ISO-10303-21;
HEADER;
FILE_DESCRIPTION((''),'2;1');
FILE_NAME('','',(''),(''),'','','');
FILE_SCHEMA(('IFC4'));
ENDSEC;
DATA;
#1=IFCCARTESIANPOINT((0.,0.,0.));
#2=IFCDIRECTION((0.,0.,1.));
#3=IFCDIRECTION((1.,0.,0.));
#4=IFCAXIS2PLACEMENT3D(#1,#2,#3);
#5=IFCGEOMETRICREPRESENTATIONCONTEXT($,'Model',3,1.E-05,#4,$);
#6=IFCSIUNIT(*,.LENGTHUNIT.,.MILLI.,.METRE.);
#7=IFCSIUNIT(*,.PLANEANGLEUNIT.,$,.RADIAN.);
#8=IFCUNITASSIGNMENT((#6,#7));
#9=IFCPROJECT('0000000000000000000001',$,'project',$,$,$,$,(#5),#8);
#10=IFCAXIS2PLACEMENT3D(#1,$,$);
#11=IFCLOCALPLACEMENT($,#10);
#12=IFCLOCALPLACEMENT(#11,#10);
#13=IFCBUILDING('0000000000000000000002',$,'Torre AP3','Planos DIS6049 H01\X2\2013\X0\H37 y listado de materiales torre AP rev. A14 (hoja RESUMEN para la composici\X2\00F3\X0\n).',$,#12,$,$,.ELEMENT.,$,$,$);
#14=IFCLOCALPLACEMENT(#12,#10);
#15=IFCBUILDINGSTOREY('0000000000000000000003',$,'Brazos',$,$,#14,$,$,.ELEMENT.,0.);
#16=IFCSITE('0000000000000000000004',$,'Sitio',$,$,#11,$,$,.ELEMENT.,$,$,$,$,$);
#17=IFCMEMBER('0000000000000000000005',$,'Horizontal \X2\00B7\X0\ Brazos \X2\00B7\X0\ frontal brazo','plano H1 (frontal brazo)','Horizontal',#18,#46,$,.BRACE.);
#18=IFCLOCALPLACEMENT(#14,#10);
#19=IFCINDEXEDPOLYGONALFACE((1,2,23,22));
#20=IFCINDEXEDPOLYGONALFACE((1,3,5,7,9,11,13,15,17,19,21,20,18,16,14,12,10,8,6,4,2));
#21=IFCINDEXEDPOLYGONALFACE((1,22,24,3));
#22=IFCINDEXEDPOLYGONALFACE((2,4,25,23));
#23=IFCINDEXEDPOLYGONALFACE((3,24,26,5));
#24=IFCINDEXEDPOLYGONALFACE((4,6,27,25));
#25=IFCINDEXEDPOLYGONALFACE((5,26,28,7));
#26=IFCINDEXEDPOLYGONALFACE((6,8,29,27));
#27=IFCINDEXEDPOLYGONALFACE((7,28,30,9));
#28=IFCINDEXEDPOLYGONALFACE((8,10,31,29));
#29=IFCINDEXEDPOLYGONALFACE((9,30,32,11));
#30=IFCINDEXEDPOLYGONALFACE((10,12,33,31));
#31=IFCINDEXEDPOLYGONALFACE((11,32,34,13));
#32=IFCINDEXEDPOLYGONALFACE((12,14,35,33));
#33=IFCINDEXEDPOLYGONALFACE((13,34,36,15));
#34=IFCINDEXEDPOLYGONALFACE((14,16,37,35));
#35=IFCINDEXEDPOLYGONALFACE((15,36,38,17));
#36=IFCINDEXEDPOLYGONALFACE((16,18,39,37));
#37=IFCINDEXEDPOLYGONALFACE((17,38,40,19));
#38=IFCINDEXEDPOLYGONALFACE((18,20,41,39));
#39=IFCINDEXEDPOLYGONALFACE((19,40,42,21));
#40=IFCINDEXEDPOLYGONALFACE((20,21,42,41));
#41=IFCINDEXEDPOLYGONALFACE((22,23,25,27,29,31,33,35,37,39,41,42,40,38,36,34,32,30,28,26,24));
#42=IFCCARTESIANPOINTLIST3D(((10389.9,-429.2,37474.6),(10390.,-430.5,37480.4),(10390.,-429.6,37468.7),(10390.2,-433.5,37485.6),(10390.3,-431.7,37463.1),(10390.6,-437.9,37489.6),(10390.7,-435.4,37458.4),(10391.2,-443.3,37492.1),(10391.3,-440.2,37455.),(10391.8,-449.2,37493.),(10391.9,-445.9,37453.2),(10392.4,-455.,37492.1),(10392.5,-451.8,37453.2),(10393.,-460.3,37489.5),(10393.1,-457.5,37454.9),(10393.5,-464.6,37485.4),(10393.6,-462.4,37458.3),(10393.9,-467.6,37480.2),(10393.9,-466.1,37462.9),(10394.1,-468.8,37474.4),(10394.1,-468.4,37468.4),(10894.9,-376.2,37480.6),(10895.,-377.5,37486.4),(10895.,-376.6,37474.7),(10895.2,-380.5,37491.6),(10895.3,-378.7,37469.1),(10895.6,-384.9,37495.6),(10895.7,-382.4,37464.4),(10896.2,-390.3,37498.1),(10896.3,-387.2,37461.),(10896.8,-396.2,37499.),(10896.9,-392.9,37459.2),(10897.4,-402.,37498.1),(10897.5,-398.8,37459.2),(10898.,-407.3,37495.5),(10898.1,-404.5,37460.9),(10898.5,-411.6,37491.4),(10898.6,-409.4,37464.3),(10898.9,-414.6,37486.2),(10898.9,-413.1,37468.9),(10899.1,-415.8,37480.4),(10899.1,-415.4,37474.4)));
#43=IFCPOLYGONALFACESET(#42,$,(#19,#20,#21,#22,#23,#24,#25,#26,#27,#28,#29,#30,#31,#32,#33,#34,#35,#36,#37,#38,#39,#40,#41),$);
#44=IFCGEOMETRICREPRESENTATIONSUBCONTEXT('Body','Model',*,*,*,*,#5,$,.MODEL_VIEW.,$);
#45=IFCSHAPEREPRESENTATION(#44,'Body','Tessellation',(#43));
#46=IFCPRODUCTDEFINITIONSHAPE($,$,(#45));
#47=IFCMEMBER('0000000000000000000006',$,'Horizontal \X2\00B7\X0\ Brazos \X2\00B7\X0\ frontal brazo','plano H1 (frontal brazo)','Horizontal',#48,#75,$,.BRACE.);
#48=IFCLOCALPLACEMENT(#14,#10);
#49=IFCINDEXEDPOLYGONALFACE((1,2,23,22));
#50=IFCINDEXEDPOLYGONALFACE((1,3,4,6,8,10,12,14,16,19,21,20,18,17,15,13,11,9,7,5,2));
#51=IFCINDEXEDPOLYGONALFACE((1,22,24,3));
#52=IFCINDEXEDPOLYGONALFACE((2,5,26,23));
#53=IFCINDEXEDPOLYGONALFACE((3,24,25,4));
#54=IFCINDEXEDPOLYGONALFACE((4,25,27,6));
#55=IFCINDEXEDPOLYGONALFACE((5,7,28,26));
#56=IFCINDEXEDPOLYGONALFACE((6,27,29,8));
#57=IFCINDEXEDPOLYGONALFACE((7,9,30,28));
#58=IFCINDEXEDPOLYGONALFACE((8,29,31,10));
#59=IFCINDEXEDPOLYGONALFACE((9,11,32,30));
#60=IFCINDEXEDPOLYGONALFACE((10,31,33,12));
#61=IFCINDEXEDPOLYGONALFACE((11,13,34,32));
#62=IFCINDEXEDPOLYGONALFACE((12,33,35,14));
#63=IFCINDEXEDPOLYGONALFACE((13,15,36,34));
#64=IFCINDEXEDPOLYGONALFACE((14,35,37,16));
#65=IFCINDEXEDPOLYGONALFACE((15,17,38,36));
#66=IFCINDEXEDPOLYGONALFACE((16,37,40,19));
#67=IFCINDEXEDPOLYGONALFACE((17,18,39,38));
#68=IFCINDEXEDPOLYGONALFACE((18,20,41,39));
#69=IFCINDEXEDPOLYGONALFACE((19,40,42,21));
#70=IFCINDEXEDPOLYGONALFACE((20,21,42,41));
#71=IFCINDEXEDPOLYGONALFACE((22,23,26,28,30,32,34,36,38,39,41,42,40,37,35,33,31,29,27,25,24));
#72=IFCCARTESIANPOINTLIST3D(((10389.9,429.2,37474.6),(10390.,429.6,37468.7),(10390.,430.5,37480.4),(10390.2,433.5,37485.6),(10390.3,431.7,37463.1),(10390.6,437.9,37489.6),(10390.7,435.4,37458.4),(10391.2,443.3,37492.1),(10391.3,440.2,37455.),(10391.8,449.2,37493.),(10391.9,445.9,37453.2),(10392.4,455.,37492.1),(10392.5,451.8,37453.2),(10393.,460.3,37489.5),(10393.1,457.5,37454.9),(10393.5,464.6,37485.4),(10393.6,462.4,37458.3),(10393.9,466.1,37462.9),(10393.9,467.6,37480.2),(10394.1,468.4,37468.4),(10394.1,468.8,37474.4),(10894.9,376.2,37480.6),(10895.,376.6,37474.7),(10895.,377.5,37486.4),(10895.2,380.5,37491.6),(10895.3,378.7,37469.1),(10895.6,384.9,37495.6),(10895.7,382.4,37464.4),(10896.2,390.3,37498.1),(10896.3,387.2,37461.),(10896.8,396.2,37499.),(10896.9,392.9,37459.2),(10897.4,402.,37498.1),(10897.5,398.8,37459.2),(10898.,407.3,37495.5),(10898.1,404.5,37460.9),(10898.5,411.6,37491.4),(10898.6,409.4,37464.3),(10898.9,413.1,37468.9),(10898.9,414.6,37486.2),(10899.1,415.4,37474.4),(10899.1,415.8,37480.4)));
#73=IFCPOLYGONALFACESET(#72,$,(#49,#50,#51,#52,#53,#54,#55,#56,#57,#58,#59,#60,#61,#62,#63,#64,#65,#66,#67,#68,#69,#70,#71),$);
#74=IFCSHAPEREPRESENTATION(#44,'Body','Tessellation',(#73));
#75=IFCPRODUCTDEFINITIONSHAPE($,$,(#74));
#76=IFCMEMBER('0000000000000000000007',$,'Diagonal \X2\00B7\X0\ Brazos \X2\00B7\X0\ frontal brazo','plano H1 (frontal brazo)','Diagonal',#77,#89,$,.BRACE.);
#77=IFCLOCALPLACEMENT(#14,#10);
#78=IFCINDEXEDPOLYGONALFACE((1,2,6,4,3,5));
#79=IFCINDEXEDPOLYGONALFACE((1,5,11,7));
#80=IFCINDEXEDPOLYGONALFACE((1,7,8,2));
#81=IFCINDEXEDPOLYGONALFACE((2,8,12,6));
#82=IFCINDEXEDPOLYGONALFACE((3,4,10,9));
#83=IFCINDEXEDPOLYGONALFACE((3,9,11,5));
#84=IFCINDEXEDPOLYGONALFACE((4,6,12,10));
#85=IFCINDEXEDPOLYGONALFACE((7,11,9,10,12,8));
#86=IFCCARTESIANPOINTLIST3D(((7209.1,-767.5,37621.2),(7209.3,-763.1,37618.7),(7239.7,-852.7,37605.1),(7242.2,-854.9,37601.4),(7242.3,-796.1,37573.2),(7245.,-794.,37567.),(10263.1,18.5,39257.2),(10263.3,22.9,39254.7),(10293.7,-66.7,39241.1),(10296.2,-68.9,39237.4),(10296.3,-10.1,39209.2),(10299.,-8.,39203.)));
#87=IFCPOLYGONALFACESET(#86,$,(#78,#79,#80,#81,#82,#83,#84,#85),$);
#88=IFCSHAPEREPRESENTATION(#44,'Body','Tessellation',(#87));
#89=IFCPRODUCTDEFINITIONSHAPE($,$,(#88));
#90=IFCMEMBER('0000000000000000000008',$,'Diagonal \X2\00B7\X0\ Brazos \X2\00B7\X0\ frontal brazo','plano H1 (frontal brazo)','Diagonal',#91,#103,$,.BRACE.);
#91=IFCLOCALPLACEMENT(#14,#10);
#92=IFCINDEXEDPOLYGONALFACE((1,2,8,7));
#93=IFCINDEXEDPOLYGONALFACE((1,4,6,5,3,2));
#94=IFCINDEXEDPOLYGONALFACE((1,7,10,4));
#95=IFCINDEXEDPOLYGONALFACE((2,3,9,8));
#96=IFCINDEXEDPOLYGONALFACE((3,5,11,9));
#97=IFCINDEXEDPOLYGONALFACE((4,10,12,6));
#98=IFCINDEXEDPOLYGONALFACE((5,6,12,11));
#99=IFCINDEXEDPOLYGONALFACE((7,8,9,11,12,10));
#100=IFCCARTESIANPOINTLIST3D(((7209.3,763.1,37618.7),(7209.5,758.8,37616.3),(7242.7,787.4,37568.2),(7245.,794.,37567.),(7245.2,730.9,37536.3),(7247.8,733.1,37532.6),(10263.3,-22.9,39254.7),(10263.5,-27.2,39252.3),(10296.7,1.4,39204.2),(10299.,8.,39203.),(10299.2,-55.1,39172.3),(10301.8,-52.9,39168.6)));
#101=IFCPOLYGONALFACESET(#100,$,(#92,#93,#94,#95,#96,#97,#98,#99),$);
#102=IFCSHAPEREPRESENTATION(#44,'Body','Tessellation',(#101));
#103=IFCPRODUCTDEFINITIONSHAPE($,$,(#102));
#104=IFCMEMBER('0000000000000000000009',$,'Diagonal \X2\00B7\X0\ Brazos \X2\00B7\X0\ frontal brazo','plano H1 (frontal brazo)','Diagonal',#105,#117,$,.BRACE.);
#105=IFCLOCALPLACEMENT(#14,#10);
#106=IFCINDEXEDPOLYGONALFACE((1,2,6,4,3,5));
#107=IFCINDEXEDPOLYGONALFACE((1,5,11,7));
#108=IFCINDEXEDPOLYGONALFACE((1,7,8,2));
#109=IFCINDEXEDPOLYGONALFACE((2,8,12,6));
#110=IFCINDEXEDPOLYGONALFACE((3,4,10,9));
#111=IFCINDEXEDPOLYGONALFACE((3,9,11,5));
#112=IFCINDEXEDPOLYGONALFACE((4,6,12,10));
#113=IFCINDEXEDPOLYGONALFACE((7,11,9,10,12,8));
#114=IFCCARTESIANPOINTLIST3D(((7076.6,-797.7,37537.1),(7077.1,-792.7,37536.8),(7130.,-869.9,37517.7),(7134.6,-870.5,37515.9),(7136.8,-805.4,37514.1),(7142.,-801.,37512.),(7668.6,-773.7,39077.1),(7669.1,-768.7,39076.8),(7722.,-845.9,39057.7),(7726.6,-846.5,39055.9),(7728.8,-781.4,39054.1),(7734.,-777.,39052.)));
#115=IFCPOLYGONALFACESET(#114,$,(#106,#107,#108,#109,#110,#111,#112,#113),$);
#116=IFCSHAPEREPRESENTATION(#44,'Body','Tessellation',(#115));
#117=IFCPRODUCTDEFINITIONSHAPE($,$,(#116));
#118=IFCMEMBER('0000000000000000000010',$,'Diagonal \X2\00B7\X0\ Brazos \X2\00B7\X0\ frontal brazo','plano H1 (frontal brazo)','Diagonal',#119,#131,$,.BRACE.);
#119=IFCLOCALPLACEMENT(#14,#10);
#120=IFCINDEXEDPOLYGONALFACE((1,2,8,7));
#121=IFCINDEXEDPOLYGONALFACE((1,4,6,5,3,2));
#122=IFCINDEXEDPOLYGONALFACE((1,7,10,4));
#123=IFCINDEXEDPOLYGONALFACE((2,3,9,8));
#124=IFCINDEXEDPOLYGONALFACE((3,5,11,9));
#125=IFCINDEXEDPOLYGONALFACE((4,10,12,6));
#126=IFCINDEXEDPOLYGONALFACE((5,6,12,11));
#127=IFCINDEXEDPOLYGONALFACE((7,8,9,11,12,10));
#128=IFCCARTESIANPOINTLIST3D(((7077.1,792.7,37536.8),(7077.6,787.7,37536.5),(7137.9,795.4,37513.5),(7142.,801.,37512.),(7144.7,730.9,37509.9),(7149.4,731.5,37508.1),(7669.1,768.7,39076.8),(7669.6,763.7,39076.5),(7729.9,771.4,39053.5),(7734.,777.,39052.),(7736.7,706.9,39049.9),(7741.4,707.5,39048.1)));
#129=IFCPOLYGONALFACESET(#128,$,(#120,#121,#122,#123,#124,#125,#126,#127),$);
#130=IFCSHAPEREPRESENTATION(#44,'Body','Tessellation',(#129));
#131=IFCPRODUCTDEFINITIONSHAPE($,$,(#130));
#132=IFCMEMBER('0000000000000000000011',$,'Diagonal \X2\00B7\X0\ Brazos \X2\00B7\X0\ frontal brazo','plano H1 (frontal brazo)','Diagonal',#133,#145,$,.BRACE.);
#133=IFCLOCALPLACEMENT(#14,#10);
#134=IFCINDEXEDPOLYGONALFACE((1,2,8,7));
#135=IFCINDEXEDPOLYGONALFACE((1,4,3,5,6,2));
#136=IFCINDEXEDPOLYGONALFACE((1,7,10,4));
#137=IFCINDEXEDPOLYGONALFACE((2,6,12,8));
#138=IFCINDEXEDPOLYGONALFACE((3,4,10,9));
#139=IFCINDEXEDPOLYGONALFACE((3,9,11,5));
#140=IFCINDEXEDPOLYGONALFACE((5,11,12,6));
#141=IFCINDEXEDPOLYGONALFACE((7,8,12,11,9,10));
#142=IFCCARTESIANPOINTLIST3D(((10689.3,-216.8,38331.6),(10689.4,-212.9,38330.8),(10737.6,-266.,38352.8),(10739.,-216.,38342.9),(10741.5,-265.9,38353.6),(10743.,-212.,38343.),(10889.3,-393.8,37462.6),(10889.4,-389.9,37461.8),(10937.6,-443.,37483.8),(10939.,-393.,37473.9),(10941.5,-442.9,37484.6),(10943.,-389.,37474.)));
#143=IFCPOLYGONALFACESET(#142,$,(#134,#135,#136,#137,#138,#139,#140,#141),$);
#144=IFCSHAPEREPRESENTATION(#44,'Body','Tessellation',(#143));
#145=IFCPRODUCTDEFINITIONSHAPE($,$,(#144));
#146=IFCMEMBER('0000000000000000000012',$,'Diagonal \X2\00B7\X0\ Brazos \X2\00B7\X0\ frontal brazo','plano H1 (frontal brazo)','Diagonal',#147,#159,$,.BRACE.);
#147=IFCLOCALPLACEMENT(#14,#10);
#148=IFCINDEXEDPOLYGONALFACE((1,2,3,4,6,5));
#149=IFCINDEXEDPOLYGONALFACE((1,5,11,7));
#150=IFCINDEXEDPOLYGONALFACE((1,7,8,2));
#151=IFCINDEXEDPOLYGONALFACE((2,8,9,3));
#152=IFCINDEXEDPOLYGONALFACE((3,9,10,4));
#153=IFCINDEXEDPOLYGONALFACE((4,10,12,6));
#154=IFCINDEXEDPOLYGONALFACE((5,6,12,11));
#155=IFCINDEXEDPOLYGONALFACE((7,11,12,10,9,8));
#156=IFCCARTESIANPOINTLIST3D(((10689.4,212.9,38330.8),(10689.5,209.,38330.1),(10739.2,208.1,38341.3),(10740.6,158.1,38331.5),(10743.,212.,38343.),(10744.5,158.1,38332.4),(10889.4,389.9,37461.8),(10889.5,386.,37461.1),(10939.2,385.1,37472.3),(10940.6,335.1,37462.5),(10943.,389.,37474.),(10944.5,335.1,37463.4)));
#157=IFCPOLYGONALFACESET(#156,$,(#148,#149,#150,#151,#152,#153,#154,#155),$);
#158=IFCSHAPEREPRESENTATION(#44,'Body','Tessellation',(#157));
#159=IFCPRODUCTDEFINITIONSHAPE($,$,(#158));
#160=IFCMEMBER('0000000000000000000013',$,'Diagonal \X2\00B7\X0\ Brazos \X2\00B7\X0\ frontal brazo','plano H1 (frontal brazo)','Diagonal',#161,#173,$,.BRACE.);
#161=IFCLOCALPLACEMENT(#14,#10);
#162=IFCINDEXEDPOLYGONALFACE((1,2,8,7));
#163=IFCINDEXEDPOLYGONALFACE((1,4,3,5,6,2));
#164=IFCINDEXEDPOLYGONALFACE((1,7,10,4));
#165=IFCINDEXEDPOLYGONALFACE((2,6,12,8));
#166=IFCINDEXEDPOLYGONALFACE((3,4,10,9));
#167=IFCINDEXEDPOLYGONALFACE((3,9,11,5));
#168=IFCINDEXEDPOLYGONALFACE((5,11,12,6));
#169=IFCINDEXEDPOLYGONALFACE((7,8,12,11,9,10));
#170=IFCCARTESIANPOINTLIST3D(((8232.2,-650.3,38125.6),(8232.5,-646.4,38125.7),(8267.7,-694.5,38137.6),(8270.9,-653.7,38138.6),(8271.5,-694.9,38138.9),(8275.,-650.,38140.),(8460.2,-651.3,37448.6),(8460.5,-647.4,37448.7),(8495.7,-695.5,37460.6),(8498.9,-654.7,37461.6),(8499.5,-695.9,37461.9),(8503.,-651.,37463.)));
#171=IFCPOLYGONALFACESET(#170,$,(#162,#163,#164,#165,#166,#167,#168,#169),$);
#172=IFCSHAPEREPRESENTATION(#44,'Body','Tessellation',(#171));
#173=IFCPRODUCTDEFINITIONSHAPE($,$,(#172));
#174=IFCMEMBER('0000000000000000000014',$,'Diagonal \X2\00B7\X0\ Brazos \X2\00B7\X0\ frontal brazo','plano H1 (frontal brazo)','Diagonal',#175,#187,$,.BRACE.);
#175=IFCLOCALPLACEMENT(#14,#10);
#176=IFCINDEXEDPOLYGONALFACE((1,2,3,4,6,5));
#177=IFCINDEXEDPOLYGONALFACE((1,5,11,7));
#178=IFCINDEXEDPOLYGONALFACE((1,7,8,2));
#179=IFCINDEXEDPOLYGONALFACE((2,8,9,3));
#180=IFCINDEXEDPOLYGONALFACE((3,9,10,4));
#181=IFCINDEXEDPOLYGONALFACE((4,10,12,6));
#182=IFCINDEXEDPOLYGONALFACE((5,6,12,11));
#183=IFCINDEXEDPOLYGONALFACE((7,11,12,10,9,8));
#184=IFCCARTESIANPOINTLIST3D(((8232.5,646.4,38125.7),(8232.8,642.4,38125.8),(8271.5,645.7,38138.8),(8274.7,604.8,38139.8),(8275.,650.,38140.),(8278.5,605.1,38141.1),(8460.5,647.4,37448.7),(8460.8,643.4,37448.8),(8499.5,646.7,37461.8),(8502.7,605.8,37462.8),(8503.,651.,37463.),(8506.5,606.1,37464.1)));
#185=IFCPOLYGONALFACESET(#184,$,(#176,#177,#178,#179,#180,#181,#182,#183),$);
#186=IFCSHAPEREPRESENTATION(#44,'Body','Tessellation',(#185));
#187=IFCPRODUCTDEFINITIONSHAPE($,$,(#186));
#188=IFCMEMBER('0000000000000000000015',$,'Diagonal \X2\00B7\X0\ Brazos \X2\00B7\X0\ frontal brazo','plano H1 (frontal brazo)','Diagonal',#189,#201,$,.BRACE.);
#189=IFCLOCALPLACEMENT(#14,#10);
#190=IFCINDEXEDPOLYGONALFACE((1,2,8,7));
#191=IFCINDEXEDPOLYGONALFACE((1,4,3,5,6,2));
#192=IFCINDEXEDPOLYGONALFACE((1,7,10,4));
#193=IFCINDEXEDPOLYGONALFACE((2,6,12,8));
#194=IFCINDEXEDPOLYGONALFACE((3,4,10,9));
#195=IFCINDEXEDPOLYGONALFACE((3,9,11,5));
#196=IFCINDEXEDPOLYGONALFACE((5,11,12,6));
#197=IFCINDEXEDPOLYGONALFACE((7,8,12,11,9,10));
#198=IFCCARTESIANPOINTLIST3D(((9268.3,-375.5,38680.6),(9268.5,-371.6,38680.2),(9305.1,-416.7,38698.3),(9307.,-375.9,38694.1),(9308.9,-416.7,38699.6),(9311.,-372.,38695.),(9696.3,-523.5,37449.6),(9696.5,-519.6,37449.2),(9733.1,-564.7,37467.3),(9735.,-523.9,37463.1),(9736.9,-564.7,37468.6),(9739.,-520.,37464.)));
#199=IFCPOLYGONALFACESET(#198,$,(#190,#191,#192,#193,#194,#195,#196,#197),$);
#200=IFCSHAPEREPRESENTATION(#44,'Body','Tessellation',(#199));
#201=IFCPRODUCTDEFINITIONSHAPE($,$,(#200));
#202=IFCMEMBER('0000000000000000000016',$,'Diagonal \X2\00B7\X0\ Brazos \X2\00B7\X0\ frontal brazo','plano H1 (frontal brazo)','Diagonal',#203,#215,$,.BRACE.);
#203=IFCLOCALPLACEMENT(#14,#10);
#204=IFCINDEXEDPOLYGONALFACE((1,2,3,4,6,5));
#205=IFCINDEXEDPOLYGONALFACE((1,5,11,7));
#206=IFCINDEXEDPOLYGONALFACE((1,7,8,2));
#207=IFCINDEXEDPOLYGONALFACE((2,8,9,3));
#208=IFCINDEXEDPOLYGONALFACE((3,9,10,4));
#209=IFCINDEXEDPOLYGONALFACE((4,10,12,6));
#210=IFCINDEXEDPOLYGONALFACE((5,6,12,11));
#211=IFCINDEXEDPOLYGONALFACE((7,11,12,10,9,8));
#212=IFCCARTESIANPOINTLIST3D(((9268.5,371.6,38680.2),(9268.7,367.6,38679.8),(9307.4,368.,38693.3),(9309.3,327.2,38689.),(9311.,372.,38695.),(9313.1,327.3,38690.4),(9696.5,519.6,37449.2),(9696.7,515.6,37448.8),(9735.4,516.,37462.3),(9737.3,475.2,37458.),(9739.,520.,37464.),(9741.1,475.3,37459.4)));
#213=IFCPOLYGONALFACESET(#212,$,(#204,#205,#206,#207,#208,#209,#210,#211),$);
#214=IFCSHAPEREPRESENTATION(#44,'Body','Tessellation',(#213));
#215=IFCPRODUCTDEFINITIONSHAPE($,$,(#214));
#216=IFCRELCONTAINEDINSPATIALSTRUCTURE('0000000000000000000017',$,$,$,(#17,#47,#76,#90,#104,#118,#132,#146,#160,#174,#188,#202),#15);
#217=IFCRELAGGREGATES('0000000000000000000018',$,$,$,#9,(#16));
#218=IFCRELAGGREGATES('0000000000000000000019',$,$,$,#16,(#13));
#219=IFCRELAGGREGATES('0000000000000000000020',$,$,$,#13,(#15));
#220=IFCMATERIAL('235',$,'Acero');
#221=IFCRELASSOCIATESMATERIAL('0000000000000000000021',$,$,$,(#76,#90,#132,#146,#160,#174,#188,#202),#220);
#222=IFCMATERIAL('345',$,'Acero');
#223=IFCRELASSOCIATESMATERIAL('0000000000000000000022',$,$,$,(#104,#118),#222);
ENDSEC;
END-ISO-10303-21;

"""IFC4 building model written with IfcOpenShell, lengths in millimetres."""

from ifc_helpers import new_model, si_unit, frame, frame_2d, origin, origin_with_axes, place, context, subcontext, project, spatial, circle, l_section, extrude, material, element, save


model = new_model("IFC4")

# Units and contexts
model_context = context("Model", 3, precision=1e-05, world=origin_with_axes())
body_context = subcontext(model_context, "Body", "Model", "MODEL_VIEW")
ifc_project = project(units=[si_unit("LENGTHUNIT", "METRE", prefix="MILLI"), si_unit("PLANEANGLEUNIT", "RADIAN")], contexts=[model_context])

# Site, building, storey
site_placement = place(None, origin())
site = spatial("IfcSite", under=ifc_project, at=site_placement, Name="Sitio", CompositionType="ELEMENT")
building_placement = place(site_placement, origin())
building = spatial("IfcBuilding", under=site, at=building_placement, Name="Torre AP3", Description="Planos DIS6049 H01–H37 y listado de materiales torre AP rev. A14 (hoja RESUMEN para la composición).", CompositionType="ELEMENT")
storey_placement = place(building_placement, origin())
storey = spatial("IfcBuildingStorey", under=building, at=storey_placement, Name="Brazos", CompositionType="ELEMENT", Elevation=0.0)

# Members
for number, where, z_axis, x_axis, name in (
    (1, (10392.0, -449.0, 37473.0), (0.994468, 0.10437, 0.011815), (-0.104986, 0.991163, 0.081074), "Horizontal · Brazos · frontal brazo"),
    (2, (10392.0, 449.0, 37473.0), (0.994468, -0.10437, 0.011815), (-0.104986, -0.991163, 0.081074), "Horizontal · Brazos · frontal brazo"),
):
    element("IfcMember", number, at=place(storey_placement, frame(where, z_axis=z_axis, x_axis=x_axis)), inside=storey, Name=name, Description="plano H1 (frontal brazo)", ObjectType="Horizontal", PredefinedType="BRACE", context=body_context, shape_type="SweptSolid", body=[
        extrude(circle(Radius=20.0), None, (0.0, 0.0, 1.0), 507.8),
    ])
ifc_material_1 = material(Name="235", Category="Acero")
for number, where, z_axis, x_axis, name in (
    (3, (7245.0, -794.0, 37567.0), (0.859644, 0.221244, 0.460503), (-0.509345, 0.441284, 0.738808), "Diagonal · Brazos · frontal brazo"),
    (4, (7245.0, 794.0, 37567.0), (0.859644, -0.221244, 0.460503), (-0.509345, -0.441284, 0.738808), "Diagonal · Brazos · frontal brazo"),
):
    element("IfcMember", number, at=place(storey_placement, frame(where, z_axis=z_axis, x_axis=x_axis)), inside=storey, material=ifc_material_1, Name=name, Description="plano H1 (frontal brazo)", ObjectType="Diagonal", PredefinedType="BRACE", context=body_context, shape_type="SweptSolid", body=[
        extrude(l_section(Depth=70.0, Width=70.0, Thickness=5.0, at=frame_2d((35.0, 35.0))), None, (0.0, 0.0, 1.0), 3552.6),
    ])
ifc_material_2 = material(Name="345", Category="Acero")
for number, where, z_axis, x_axis, name in (
    (5, (7142.0, -801.0, 37512.0), (0.358779, 0.014545, 0.933309), (-0.927462, 0.118373, 0.354686), "Diagonal · Brazos · frontal brazo"),
    (6, (7142.0, 801.0, 37512.0), (0.358779, -0.014545, 0.933309), (-0.927462, -0.118373, 0.354686), "Diagonal · Brazos · frontal brazo"),
):
    element("IfcMember", number, at=place(storey_placement, frame(where, z_axis=z_axis, x_axis=x_axis)), inside=storey, material=ifc_material_2, Name=name, Description="plano H1 (frontal brazo)", ObjectType="Diagonal", PredefinedType="BRACE", context=body_context, shape_type="SweptSolid", body=[
        extrude(l_section(Depth=70.0, Width=70.0, Thickness=5.0, at=frame_2d((35.0, 35.0))), None, (0.0, 0.0, 1.0), 1650.0),
    ])
for number, where, z_axis, x_axis, name in (
    (7, (10943.0, -389.0, 37474.0), (-0.219994, 0.194695, 0.955875), (-0.975122, -0.016589, -0.221045), "Diagonal · Brazos · frontal brazo"),
    (8, (10943.0, 389.0, 37474.0), (-0.219994, -0.194695, 0.955875), (-0.975122, 0.016589, -0.221045), "Diagonal · Brazos · frontal brazo"),
):
    element("IfcMember", number, at=place(storey_placement, frame(where, z_axis=z_axis, x_axis=x_axis)), inside=storey, material=ifc_material_1, Name=name, Description="plano H1 (frontal brazo)", ObjectType="Diagonal", PredefinedType="BRACE", context=body_context, shape_type="SweptSolid", body=[
        extrude(l_section(Depth=55.0, Width=55.0, Thickness=4.0, at=frame_2d((27.5, 27.5))), None, (0.0, 0.0, 1.0), 909.1),
    ])
for number, where, z_axis, x_axis, name in (
    (9, (8503.0, -651.0, 37463.0), (-0.319166, 0.0014, 0.947698), (-0.944542, 0.081082, -0.318223), "Diagonal · Brazos · frontal brazo"),
    (10, (8503.0, 651.0, 37463.0), (-0.319166, -0.0014, 0.947698), (-0.944542, -0.081082, -0.318223), "Diagonal · Brazos · frontal brazo"),
):
    element("IfcMember", number, at=place(storey_placement, frame(where, z_axis=z_axis, x_axis=x_axis)), inside=storey, material=ifc_material_1, Name=name, Description="plano H1 (frontal brazo)", ObjectType="Diagonal", PredefinedType="BRACE", context=body_context, shape_type="SweptSolid", body=[
        extrude(l_section(Depth=45.0, Width=45.0, Thickness=4.0, at=frame_2d((22.5, 22.5))), None, (0.0, 0.0, 1.0), 714.4),
    ])
for number, where, z_axis, x_axis, name in (
    (11, (9739.0, -520.0, 37464.0), (-0.326304, 0.112834, 0.938506), (-0.944119, 0.009962, -0.329454), "Diagonal · Brazos · frontal brazo"),
    (12, (9739.0, 520.0, 37464.0), (-0.326304, -0.112834, 0.938506), (-0.944119, -0.009962, -0.329454), "Diagonal · Brazos · frontal brazo"),
):
    element("IfcMember", number, at=place(storey_placement, frame(where, z_axis=z_axis, x_axis=x_axis)), inside=storey, material=ifc_material_1, Name=name, Description="plano H1 (frontal brazo)", ObjectType="Diagonal", PredefinedType="BRACE", context=body_context, shape_type="SweptSolid", body=[
        extrude(l_section(Depth=45.0, Width=45.0, Thickness=4.0, at=frame_2d((22.5, 22.5))), None, (0.0, 0.0, 1.0), 1311.7),
    ])

save(model, "model.ifc")
